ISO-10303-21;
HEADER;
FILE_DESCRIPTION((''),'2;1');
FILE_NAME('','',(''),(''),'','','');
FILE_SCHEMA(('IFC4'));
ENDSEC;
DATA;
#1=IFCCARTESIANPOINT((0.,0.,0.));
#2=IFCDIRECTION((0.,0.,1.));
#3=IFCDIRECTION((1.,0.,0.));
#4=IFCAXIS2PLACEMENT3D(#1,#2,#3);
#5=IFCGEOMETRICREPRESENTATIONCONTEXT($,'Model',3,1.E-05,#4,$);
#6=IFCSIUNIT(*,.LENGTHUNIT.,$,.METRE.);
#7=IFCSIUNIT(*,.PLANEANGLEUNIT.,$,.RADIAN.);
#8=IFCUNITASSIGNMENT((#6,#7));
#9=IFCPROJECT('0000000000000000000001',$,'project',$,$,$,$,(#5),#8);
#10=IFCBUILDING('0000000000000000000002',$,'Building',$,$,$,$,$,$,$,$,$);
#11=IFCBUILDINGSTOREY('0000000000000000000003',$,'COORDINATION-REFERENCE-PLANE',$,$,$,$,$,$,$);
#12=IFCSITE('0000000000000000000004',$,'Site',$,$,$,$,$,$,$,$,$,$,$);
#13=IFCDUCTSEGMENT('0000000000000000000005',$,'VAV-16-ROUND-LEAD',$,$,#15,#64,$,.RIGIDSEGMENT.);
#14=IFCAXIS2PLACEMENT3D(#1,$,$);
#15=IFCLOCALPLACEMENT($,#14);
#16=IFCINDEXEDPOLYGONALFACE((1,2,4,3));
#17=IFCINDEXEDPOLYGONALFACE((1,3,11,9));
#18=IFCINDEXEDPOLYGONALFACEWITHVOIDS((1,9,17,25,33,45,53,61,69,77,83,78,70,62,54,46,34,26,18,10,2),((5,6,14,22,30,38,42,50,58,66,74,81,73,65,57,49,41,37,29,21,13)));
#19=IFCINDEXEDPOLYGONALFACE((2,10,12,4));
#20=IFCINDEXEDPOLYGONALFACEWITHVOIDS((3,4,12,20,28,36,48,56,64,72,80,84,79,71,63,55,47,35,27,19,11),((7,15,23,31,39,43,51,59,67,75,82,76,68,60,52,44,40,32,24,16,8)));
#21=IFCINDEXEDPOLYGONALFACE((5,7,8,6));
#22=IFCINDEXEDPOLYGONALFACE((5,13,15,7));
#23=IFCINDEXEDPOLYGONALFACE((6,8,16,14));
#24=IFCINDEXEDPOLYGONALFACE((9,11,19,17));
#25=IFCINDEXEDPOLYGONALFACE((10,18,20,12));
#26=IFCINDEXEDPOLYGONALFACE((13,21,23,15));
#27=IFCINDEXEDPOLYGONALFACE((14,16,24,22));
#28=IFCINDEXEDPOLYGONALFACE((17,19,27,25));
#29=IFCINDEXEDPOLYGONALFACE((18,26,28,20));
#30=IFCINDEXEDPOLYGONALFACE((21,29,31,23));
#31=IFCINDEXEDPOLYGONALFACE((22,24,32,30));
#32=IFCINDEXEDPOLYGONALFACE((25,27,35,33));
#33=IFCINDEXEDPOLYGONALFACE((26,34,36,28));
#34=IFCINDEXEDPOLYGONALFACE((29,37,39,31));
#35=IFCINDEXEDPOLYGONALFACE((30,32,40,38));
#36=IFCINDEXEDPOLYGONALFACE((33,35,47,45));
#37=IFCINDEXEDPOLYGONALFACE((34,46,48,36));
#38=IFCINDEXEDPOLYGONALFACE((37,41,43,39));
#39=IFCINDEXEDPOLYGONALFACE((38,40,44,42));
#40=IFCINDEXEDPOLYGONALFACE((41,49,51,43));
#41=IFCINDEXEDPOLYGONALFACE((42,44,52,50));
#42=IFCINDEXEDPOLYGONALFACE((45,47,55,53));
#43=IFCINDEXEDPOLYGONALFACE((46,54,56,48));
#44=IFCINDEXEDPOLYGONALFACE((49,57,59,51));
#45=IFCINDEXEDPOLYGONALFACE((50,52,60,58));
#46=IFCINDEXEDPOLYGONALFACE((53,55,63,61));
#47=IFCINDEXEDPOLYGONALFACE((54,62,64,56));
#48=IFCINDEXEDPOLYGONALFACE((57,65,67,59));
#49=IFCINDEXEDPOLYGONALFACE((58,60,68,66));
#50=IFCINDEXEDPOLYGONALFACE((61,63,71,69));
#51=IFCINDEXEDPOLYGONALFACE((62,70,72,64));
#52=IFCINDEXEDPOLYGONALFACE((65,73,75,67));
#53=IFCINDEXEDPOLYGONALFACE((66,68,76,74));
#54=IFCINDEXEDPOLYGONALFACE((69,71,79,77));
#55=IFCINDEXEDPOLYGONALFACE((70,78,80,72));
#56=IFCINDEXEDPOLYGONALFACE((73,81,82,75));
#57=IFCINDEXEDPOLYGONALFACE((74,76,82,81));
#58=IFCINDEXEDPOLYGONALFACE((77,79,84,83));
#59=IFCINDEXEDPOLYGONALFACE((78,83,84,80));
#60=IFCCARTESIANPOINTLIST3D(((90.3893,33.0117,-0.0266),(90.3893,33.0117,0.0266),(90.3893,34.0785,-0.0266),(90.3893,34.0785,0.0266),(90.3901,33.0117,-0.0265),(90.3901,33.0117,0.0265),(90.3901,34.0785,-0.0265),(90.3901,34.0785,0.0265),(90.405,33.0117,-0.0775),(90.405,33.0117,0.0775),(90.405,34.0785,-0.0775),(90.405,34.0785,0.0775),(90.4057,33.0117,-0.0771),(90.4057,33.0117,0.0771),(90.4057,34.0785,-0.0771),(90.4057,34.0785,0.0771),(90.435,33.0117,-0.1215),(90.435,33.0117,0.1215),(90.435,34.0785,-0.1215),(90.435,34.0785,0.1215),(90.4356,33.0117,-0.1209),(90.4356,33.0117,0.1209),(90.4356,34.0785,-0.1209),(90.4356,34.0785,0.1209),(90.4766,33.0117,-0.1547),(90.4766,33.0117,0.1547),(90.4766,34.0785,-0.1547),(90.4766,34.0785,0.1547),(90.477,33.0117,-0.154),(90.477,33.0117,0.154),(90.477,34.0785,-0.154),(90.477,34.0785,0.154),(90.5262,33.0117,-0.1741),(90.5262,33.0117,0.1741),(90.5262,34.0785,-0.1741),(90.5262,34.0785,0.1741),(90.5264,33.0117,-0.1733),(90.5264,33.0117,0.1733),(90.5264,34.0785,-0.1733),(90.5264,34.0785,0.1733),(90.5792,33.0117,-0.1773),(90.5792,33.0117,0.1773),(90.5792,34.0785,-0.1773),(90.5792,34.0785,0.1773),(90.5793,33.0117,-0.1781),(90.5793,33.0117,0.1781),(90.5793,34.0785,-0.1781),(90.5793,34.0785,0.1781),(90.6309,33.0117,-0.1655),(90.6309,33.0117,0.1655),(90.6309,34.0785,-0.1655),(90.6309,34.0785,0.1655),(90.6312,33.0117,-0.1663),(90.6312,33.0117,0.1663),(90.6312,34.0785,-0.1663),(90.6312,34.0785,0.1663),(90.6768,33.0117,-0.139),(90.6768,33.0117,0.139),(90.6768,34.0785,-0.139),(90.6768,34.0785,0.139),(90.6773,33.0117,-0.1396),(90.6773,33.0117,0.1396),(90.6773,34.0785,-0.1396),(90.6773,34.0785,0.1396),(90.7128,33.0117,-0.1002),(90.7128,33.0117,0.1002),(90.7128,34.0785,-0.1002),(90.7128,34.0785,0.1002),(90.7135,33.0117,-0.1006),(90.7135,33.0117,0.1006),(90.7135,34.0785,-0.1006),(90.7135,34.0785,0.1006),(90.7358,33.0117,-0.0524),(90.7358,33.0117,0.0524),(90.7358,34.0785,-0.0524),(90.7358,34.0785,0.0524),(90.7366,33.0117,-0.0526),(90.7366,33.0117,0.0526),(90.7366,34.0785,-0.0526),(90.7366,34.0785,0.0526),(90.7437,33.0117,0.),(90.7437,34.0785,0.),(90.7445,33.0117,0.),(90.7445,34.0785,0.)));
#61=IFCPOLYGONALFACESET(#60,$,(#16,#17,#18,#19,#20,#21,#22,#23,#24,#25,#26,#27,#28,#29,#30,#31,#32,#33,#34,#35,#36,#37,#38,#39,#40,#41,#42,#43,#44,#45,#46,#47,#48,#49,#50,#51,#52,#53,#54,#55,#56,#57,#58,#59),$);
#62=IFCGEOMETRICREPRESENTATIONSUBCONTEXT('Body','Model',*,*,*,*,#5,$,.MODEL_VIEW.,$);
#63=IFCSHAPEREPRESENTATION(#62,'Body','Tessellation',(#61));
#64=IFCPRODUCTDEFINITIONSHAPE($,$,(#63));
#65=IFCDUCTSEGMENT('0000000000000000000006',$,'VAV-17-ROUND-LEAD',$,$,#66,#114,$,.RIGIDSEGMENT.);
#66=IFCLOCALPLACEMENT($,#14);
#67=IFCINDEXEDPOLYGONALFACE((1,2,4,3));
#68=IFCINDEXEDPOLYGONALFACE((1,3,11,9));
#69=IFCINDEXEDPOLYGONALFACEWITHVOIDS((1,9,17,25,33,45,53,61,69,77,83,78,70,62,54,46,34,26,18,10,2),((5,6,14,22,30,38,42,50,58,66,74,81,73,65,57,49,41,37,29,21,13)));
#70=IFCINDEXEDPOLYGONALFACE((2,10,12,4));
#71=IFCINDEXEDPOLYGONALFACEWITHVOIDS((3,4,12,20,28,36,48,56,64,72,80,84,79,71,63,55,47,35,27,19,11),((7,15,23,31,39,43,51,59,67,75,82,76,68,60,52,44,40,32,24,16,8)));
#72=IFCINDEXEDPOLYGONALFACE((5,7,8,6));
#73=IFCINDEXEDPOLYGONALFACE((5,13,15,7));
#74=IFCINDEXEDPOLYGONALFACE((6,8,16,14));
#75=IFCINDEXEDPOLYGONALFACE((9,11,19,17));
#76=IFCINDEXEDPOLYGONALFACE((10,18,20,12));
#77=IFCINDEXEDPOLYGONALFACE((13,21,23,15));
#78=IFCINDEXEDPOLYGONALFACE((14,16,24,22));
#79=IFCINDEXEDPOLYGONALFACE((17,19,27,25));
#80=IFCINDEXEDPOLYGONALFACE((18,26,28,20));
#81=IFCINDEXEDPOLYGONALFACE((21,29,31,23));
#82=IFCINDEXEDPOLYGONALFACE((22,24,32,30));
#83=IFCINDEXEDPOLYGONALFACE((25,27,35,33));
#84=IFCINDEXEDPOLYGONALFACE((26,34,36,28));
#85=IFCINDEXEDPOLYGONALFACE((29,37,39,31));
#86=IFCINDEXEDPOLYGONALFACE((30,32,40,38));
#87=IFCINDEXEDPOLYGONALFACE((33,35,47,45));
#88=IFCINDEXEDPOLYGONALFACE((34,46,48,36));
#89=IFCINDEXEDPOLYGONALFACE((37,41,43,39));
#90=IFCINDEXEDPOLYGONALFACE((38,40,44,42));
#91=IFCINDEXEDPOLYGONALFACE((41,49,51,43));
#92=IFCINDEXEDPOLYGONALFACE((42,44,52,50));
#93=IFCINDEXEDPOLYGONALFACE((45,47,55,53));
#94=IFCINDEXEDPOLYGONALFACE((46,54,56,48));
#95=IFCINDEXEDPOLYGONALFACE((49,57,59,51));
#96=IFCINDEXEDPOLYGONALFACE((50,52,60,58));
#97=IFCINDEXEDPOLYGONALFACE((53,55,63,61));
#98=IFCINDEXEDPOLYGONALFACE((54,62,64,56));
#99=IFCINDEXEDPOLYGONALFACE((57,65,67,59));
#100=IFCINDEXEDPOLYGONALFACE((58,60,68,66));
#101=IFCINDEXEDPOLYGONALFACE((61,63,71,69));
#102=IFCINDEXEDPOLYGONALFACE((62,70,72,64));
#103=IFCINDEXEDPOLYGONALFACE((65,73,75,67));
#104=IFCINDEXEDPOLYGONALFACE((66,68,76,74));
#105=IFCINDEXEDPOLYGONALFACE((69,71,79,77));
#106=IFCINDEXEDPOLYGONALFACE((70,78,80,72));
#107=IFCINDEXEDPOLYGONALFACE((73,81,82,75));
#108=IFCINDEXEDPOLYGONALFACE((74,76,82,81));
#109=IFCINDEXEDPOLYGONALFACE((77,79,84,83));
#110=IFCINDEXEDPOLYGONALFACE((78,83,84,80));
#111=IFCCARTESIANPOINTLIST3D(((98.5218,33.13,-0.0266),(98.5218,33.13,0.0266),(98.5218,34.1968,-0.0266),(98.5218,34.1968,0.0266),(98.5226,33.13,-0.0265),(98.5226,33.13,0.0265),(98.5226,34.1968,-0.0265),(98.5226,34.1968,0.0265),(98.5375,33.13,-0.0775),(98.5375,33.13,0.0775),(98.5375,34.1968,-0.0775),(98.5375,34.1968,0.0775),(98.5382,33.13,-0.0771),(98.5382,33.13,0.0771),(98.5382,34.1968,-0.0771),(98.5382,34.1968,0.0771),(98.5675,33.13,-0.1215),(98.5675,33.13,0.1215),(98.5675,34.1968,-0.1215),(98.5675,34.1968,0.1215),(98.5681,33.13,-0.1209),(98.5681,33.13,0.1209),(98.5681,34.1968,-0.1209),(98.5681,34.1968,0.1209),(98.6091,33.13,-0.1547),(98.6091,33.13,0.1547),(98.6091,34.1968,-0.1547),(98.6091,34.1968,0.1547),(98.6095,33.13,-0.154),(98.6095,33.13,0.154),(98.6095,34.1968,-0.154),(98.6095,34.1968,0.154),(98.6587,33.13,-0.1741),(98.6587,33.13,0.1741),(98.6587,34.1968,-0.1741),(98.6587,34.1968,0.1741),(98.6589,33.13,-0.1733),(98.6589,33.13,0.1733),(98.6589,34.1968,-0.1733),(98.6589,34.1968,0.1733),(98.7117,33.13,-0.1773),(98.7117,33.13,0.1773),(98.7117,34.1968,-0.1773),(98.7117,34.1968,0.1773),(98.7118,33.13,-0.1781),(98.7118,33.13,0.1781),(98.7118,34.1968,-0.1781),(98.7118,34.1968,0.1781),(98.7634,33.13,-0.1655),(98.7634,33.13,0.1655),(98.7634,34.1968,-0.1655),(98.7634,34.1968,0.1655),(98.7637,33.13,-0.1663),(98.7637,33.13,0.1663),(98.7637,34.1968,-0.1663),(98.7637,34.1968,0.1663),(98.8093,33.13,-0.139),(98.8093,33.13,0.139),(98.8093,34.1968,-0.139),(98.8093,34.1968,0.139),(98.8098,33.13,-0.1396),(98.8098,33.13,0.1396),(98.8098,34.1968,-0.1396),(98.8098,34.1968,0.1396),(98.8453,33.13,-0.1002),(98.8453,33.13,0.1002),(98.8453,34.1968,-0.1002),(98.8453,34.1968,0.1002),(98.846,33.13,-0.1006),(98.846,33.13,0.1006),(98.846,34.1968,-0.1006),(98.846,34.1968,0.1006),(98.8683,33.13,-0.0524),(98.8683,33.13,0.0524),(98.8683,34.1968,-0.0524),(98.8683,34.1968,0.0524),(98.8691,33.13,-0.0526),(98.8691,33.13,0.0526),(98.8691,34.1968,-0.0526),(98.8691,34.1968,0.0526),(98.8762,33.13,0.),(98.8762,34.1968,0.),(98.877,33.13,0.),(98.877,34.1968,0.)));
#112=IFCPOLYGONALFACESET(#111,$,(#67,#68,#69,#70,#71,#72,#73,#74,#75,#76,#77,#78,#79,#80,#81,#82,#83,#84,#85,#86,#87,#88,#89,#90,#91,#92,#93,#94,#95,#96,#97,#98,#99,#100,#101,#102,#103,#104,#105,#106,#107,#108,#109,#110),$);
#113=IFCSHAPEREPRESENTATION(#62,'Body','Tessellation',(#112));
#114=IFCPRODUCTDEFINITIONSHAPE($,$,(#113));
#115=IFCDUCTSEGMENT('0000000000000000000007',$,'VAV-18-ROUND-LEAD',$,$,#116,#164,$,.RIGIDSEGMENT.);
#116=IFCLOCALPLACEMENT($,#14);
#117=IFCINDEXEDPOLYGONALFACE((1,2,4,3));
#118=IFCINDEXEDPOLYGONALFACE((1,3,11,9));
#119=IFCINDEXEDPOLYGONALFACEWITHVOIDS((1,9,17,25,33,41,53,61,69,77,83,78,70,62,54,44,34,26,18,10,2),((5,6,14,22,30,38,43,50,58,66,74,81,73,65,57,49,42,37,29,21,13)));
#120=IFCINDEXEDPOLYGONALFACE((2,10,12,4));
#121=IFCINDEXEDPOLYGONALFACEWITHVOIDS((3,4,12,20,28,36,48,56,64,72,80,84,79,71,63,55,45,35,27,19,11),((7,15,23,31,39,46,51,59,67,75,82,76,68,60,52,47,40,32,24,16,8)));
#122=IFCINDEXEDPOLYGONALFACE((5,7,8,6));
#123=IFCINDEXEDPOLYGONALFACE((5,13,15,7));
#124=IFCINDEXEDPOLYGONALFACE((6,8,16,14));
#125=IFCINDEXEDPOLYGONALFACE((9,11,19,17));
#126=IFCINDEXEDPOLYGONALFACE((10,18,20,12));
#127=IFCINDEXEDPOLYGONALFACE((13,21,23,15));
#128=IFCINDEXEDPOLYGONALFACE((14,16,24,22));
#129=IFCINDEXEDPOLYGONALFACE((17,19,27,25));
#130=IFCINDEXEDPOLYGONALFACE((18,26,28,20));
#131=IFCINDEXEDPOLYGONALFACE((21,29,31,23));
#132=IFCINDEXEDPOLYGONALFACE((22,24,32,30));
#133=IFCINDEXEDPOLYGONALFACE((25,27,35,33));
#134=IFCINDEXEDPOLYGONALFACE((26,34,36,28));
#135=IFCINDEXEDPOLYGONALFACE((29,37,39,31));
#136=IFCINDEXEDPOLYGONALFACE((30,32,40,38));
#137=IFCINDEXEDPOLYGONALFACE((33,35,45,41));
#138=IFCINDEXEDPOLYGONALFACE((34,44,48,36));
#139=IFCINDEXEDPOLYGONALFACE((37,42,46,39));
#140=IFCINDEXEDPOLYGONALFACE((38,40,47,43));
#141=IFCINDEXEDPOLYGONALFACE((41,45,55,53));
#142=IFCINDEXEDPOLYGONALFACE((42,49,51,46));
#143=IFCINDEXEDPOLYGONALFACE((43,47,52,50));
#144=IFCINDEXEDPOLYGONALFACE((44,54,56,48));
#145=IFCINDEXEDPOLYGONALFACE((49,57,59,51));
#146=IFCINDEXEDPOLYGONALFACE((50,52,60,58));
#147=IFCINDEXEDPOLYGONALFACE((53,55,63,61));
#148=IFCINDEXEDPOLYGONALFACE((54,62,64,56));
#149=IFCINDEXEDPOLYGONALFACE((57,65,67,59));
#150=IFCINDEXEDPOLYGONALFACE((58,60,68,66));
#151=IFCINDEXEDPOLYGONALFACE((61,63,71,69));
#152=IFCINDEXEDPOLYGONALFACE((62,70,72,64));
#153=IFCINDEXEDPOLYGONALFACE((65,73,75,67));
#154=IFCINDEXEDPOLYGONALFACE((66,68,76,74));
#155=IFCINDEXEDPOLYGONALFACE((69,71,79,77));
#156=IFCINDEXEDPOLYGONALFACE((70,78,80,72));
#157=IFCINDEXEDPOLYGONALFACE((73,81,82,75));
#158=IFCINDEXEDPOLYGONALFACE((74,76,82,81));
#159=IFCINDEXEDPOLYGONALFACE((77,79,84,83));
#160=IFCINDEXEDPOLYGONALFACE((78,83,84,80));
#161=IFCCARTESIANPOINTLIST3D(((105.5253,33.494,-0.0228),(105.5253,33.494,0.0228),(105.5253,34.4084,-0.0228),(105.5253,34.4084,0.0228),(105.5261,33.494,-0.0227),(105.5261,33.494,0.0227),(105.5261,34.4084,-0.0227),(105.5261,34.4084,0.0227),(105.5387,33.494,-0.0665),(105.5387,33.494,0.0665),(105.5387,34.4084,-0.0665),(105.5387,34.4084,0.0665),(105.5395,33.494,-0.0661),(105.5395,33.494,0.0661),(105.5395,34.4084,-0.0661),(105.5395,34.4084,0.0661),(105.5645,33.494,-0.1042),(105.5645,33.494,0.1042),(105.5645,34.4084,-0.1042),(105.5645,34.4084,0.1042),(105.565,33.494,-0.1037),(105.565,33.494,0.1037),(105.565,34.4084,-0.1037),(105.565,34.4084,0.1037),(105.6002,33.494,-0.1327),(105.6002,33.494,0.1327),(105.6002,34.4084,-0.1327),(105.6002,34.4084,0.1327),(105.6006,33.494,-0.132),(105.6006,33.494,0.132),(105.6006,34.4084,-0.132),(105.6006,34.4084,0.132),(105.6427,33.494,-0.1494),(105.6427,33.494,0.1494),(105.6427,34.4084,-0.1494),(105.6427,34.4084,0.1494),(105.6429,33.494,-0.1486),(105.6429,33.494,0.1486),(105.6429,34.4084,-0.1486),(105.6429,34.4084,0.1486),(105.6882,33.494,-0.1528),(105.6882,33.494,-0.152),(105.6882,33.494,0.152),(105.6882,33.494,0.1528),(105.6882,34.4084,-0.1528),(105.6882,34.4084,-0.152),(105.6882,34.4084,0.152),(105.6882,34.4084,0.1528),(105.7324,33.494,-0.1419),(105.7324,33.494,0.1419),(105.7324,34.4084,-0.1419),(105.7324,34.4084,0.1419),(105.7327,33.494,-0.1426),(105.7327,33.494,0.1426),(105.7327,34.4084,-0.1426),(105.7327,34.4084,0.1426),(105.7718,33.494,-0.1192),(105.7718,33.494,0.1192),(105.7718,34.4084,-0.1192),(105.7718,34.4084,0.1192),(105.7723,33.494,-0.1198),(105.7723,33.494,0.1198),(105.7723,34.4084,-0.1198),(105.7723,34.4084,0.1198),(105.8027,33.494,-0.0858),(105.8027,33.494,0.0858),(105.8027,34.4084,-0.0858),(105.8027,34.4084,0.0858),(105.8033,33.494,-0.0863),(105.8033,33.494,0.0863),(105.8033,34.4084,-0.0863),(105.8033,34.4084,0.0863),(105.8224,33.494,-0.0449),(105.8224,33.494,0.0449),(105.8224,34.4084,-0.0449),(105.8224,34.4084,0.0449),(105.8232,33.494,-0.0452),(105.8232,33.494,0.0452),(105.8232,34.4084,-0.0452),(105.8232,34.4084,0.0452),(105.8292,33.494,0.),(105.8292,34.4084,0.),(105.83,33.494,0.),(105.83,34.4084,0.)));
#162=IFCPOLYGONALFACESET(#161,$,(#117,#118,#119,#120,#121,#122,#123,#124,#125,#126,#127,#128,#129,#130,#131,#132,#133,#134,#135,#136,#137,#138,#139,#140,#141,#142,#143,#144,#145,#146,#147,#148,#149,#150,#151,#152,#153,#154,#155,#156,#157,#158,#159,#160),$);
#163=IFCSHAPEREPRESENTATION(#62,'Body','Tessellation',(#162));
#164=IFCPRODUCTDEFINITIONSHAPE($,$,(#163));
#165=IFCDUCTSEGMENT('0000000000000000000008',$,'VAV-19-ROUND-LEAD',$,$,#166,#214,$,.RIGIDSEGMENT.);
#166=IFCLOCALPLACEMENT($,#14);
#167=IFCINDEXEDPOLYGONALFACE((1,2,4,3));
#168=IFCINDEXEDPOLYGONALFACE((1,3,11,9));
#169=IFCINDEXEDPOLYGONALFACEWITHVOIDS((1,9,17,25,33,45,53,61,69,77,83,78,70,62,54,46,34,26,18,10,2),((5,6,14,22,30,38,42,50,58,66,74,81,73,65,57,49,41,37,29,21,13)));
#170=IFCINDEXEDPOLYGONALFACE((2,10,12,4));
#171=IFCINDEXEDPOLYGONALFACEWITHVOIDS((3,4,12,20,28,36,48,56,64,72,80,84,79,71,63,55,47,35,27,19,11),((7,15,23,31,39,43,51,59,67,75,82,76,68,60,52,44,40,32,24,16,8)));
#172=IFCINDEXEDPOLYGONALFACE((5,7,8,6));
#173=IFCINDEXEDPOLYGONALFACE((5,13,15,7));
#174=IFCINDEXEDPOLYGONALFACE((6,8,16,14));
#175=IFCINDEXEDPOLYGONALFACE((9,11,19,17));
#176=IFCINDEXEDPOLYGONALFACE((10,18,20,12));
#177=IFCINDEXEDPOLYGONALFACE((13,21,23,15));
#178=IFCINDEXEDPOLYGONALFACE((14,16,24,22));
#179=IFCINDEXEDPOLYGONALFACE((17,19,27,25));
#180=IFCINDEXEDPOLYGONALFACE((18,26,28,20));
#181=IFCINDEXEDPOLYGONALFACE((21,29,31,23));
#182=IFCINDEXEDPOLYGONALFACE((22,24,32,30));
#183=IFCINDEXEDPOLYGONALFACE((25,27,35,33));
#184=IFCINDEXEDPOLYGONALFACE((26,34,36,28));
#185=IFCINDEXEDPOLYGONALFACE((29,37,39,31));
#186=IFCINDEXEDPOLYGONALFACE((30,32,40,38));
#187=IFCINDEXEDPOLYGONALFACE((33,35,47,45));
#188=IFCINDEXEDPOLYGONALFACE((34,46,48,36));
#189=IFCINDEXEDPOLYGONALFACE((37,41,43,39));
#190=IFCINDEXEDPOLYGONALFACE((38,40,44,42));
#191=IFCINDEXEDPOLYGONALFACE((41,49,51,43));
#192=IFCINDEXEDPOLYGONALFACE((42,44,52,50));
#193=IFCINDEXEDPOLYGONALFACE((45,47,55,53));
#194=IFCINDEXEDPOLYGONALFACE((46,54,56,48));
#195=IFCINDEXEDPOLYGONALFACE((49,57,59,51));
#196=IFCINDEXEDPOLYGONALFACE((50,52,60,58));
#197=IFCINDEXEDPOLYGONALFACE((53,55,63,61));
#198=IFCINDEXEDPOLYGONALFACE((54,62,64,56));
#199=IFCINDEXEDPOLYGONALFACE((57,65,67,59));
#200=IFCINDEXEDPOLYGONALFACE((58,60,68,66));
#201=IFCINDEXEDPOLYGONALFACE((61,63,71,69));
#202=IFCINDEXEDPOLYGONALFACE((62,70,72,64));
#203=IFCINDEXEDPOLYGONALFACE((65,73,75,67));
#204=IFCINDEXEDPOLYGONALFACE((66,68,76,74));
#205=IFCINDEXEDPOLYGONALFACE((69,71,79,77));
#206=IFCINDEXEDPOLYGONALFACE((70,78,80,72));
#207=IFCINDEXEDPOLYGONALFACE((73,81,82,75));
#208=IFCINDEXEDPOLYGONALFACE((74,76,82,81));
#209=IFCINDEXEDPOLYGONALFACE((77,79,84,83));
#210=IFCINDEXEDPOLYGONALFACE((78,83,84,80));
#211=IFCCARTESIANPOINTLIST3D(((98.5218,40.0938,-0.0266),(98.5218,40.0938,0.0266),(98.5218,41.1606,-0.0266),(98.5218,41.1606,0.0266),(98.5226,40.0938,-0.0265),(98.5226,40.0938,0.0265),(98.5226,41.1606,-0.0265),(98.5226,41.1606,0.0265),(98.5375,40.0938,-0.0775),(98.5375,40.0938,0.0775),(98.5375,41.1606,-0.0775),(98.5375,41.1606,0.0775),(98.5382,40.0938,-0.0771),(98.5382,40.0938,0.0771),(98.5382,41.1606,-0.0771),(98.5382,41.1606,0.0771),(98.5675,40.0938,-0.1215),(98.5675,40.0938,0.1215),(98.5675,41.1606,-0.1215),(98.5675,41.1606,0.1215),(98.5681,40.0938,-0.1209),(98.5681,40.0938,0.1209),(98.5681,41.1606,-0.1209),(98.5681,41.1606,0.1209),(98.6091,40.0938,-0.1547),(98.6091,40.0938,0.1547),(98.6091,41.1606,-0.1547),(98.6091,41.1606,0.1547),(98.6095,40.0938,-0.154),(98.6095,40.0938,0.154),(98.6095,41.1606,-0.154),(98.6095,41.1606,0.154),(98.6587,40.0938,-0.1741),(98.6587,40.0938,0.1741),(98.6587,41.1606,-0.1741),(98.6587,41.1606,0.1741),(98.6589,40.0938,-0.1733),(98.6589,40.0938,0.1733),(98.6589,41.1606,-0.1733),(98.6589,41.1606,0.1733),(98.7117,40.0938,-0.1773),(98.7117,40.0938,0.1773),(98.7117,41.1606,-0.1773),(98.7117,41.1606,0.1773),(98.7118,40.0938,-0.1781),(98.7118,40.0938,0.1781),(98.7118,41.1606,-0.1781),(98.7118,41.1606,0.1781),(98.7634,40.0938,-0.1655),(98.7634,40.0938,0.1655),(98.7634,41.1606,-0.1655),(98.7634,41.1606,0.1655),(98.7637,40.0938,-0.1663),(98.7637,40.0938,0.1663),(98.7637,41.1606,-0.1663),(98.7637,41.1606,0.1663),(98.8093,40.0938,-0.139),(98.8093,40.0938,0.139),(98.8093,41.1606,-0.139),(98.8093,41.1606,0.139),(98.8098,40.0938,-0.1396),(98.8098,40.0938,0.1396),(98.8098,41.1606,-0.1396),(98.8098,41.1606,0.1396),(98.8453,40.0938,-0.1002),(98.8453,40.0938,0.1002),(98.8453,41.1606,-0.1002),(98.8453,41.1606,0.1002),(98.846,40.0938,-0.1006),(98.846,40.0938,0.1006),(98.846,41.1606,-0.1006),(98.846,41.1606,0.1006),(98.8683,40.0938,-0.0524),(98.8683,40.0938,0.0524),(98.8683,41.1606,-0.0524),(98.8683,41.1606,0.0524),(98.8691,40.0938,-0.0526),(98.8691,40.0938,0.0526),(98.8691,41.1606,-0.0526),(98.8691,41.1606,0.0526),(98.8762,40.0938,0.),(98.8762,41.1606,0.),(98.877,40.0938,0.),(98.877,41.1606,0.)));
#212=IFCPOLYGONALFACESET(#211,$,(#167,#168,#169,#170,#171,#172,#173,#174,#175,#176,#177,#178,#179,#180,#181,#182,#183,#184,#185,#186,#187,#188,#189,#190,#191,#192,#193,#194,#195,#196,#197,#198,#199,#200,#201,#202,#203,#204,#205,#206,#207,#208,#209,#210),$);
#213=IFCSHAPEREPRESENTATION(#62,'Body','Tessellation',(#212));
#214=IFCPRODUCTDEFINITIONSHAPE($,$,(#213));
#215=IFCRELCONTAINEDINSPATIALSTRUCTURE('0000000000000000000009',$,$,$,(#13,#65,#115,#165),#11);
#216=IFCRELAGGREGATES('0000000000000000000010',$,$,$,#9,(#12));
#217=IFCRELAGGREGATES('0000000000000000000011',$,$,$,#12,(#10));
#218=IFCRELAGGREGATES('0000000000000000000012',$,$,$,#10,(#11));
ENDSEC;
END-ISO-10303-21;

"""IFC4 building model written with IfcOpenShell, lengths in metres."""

from ifc_helpers import new_model, si_unit, frame, origin, origin_with_axes, place, context, subcontext, project, spatial, hollow_circle, extrude, element, save


model = new_model("IFC4")

# Units and contexts
model_context = context("Model", 3, precision=1e-05, world=origin_with_axes())
body_context_1 = subcontext(model_context, "Body", "Model", "MODEL_VIEW")
ifc_project = project(units=[si_unit("LENGTHUNIT", "METRE"), si_unit("PLANEANGLEUNIT", "RADIAN")], contexts=[model_context])

# Site, building, storey
site = spatial("IfcSite", under=ifc_project, Name="Site")
building = spatial("IfcBuilding", under=site, Name="Building")
storey = spatial("IfcBuildingStorey", under=building, Name="COORDINATION-REFERENCE-PLANE")

# Duct segments
for number, where, z_axis, x_axis, name in (
    (1, (90.5659, 34.0785, 0.0), (0.0, -1.0, 0.0), (1.0, 0.0, 0.0), "VAV-16-ROUND-LEAD"),
    (2, (98.6984, 34.1968, 0.0), (0.0, -1.0, 0.0), (1.0, 0.0, 0.0), "VAV-17-ROUND-LEAD"),
):
    element("IfcDuctSegment", number, at=place(None, frame(where, z_axis=z_axis, x_axis=x_axis)), inside=storey, Name=name, PredefinedType="RIGIDSEGMENT", context=body_context_1, shape_type="SweptSolid", body=[
        extrude(hollow_circle(Radius=0.1786, WallThickness=0.0008), origin(), (0.0, 0.0, 1.0), 1.0668),
    ])
duct_segment_1_placement = place(None, frame((105.6768, 34.4084, 0.0), z_axis=(0.0, -1.0, 0.0), x_axis=(1.0, 0.0, 0.0)))
element("IfcDuctSegment", 3, at=duct_segment_1_placement, inside=storey, Name="VAV-18-ROUND-LEAD", PredefinedType="RIGIDSEGMENT", context=body_context_1, shape_type="SweptSolid", body=[
    extrude(hollow_circle(Radius=0.1532, WallThickness=0.0008), origin(), (0.0, 0.0, 1.0), 0.9144),
])
for number, where, z_axis, x_axis, name in (
    (4, (98.6984, 40.0938, 0.0), (0.0, 1.0, 0.0), (1.0, 0.0, 0.0), "VAV-19-ROUND-LEAD"),
):
    element("IfcDuctSegment", number, at=place(None, frame(where, z_axis=z_axis, x_axis=x_axis)), inside=storey, Name=name, PredefinedType="RIGIDSEGMENT", context=body_context_1, shape_type="SweptSolid", body=[
        extrude(hollow_circle(Radius=0.1786, WallThickness=0.0008), origin(), (0.0, 0.0, 1.0), 1.0668),
    ])

save(model, "model.ifc")
